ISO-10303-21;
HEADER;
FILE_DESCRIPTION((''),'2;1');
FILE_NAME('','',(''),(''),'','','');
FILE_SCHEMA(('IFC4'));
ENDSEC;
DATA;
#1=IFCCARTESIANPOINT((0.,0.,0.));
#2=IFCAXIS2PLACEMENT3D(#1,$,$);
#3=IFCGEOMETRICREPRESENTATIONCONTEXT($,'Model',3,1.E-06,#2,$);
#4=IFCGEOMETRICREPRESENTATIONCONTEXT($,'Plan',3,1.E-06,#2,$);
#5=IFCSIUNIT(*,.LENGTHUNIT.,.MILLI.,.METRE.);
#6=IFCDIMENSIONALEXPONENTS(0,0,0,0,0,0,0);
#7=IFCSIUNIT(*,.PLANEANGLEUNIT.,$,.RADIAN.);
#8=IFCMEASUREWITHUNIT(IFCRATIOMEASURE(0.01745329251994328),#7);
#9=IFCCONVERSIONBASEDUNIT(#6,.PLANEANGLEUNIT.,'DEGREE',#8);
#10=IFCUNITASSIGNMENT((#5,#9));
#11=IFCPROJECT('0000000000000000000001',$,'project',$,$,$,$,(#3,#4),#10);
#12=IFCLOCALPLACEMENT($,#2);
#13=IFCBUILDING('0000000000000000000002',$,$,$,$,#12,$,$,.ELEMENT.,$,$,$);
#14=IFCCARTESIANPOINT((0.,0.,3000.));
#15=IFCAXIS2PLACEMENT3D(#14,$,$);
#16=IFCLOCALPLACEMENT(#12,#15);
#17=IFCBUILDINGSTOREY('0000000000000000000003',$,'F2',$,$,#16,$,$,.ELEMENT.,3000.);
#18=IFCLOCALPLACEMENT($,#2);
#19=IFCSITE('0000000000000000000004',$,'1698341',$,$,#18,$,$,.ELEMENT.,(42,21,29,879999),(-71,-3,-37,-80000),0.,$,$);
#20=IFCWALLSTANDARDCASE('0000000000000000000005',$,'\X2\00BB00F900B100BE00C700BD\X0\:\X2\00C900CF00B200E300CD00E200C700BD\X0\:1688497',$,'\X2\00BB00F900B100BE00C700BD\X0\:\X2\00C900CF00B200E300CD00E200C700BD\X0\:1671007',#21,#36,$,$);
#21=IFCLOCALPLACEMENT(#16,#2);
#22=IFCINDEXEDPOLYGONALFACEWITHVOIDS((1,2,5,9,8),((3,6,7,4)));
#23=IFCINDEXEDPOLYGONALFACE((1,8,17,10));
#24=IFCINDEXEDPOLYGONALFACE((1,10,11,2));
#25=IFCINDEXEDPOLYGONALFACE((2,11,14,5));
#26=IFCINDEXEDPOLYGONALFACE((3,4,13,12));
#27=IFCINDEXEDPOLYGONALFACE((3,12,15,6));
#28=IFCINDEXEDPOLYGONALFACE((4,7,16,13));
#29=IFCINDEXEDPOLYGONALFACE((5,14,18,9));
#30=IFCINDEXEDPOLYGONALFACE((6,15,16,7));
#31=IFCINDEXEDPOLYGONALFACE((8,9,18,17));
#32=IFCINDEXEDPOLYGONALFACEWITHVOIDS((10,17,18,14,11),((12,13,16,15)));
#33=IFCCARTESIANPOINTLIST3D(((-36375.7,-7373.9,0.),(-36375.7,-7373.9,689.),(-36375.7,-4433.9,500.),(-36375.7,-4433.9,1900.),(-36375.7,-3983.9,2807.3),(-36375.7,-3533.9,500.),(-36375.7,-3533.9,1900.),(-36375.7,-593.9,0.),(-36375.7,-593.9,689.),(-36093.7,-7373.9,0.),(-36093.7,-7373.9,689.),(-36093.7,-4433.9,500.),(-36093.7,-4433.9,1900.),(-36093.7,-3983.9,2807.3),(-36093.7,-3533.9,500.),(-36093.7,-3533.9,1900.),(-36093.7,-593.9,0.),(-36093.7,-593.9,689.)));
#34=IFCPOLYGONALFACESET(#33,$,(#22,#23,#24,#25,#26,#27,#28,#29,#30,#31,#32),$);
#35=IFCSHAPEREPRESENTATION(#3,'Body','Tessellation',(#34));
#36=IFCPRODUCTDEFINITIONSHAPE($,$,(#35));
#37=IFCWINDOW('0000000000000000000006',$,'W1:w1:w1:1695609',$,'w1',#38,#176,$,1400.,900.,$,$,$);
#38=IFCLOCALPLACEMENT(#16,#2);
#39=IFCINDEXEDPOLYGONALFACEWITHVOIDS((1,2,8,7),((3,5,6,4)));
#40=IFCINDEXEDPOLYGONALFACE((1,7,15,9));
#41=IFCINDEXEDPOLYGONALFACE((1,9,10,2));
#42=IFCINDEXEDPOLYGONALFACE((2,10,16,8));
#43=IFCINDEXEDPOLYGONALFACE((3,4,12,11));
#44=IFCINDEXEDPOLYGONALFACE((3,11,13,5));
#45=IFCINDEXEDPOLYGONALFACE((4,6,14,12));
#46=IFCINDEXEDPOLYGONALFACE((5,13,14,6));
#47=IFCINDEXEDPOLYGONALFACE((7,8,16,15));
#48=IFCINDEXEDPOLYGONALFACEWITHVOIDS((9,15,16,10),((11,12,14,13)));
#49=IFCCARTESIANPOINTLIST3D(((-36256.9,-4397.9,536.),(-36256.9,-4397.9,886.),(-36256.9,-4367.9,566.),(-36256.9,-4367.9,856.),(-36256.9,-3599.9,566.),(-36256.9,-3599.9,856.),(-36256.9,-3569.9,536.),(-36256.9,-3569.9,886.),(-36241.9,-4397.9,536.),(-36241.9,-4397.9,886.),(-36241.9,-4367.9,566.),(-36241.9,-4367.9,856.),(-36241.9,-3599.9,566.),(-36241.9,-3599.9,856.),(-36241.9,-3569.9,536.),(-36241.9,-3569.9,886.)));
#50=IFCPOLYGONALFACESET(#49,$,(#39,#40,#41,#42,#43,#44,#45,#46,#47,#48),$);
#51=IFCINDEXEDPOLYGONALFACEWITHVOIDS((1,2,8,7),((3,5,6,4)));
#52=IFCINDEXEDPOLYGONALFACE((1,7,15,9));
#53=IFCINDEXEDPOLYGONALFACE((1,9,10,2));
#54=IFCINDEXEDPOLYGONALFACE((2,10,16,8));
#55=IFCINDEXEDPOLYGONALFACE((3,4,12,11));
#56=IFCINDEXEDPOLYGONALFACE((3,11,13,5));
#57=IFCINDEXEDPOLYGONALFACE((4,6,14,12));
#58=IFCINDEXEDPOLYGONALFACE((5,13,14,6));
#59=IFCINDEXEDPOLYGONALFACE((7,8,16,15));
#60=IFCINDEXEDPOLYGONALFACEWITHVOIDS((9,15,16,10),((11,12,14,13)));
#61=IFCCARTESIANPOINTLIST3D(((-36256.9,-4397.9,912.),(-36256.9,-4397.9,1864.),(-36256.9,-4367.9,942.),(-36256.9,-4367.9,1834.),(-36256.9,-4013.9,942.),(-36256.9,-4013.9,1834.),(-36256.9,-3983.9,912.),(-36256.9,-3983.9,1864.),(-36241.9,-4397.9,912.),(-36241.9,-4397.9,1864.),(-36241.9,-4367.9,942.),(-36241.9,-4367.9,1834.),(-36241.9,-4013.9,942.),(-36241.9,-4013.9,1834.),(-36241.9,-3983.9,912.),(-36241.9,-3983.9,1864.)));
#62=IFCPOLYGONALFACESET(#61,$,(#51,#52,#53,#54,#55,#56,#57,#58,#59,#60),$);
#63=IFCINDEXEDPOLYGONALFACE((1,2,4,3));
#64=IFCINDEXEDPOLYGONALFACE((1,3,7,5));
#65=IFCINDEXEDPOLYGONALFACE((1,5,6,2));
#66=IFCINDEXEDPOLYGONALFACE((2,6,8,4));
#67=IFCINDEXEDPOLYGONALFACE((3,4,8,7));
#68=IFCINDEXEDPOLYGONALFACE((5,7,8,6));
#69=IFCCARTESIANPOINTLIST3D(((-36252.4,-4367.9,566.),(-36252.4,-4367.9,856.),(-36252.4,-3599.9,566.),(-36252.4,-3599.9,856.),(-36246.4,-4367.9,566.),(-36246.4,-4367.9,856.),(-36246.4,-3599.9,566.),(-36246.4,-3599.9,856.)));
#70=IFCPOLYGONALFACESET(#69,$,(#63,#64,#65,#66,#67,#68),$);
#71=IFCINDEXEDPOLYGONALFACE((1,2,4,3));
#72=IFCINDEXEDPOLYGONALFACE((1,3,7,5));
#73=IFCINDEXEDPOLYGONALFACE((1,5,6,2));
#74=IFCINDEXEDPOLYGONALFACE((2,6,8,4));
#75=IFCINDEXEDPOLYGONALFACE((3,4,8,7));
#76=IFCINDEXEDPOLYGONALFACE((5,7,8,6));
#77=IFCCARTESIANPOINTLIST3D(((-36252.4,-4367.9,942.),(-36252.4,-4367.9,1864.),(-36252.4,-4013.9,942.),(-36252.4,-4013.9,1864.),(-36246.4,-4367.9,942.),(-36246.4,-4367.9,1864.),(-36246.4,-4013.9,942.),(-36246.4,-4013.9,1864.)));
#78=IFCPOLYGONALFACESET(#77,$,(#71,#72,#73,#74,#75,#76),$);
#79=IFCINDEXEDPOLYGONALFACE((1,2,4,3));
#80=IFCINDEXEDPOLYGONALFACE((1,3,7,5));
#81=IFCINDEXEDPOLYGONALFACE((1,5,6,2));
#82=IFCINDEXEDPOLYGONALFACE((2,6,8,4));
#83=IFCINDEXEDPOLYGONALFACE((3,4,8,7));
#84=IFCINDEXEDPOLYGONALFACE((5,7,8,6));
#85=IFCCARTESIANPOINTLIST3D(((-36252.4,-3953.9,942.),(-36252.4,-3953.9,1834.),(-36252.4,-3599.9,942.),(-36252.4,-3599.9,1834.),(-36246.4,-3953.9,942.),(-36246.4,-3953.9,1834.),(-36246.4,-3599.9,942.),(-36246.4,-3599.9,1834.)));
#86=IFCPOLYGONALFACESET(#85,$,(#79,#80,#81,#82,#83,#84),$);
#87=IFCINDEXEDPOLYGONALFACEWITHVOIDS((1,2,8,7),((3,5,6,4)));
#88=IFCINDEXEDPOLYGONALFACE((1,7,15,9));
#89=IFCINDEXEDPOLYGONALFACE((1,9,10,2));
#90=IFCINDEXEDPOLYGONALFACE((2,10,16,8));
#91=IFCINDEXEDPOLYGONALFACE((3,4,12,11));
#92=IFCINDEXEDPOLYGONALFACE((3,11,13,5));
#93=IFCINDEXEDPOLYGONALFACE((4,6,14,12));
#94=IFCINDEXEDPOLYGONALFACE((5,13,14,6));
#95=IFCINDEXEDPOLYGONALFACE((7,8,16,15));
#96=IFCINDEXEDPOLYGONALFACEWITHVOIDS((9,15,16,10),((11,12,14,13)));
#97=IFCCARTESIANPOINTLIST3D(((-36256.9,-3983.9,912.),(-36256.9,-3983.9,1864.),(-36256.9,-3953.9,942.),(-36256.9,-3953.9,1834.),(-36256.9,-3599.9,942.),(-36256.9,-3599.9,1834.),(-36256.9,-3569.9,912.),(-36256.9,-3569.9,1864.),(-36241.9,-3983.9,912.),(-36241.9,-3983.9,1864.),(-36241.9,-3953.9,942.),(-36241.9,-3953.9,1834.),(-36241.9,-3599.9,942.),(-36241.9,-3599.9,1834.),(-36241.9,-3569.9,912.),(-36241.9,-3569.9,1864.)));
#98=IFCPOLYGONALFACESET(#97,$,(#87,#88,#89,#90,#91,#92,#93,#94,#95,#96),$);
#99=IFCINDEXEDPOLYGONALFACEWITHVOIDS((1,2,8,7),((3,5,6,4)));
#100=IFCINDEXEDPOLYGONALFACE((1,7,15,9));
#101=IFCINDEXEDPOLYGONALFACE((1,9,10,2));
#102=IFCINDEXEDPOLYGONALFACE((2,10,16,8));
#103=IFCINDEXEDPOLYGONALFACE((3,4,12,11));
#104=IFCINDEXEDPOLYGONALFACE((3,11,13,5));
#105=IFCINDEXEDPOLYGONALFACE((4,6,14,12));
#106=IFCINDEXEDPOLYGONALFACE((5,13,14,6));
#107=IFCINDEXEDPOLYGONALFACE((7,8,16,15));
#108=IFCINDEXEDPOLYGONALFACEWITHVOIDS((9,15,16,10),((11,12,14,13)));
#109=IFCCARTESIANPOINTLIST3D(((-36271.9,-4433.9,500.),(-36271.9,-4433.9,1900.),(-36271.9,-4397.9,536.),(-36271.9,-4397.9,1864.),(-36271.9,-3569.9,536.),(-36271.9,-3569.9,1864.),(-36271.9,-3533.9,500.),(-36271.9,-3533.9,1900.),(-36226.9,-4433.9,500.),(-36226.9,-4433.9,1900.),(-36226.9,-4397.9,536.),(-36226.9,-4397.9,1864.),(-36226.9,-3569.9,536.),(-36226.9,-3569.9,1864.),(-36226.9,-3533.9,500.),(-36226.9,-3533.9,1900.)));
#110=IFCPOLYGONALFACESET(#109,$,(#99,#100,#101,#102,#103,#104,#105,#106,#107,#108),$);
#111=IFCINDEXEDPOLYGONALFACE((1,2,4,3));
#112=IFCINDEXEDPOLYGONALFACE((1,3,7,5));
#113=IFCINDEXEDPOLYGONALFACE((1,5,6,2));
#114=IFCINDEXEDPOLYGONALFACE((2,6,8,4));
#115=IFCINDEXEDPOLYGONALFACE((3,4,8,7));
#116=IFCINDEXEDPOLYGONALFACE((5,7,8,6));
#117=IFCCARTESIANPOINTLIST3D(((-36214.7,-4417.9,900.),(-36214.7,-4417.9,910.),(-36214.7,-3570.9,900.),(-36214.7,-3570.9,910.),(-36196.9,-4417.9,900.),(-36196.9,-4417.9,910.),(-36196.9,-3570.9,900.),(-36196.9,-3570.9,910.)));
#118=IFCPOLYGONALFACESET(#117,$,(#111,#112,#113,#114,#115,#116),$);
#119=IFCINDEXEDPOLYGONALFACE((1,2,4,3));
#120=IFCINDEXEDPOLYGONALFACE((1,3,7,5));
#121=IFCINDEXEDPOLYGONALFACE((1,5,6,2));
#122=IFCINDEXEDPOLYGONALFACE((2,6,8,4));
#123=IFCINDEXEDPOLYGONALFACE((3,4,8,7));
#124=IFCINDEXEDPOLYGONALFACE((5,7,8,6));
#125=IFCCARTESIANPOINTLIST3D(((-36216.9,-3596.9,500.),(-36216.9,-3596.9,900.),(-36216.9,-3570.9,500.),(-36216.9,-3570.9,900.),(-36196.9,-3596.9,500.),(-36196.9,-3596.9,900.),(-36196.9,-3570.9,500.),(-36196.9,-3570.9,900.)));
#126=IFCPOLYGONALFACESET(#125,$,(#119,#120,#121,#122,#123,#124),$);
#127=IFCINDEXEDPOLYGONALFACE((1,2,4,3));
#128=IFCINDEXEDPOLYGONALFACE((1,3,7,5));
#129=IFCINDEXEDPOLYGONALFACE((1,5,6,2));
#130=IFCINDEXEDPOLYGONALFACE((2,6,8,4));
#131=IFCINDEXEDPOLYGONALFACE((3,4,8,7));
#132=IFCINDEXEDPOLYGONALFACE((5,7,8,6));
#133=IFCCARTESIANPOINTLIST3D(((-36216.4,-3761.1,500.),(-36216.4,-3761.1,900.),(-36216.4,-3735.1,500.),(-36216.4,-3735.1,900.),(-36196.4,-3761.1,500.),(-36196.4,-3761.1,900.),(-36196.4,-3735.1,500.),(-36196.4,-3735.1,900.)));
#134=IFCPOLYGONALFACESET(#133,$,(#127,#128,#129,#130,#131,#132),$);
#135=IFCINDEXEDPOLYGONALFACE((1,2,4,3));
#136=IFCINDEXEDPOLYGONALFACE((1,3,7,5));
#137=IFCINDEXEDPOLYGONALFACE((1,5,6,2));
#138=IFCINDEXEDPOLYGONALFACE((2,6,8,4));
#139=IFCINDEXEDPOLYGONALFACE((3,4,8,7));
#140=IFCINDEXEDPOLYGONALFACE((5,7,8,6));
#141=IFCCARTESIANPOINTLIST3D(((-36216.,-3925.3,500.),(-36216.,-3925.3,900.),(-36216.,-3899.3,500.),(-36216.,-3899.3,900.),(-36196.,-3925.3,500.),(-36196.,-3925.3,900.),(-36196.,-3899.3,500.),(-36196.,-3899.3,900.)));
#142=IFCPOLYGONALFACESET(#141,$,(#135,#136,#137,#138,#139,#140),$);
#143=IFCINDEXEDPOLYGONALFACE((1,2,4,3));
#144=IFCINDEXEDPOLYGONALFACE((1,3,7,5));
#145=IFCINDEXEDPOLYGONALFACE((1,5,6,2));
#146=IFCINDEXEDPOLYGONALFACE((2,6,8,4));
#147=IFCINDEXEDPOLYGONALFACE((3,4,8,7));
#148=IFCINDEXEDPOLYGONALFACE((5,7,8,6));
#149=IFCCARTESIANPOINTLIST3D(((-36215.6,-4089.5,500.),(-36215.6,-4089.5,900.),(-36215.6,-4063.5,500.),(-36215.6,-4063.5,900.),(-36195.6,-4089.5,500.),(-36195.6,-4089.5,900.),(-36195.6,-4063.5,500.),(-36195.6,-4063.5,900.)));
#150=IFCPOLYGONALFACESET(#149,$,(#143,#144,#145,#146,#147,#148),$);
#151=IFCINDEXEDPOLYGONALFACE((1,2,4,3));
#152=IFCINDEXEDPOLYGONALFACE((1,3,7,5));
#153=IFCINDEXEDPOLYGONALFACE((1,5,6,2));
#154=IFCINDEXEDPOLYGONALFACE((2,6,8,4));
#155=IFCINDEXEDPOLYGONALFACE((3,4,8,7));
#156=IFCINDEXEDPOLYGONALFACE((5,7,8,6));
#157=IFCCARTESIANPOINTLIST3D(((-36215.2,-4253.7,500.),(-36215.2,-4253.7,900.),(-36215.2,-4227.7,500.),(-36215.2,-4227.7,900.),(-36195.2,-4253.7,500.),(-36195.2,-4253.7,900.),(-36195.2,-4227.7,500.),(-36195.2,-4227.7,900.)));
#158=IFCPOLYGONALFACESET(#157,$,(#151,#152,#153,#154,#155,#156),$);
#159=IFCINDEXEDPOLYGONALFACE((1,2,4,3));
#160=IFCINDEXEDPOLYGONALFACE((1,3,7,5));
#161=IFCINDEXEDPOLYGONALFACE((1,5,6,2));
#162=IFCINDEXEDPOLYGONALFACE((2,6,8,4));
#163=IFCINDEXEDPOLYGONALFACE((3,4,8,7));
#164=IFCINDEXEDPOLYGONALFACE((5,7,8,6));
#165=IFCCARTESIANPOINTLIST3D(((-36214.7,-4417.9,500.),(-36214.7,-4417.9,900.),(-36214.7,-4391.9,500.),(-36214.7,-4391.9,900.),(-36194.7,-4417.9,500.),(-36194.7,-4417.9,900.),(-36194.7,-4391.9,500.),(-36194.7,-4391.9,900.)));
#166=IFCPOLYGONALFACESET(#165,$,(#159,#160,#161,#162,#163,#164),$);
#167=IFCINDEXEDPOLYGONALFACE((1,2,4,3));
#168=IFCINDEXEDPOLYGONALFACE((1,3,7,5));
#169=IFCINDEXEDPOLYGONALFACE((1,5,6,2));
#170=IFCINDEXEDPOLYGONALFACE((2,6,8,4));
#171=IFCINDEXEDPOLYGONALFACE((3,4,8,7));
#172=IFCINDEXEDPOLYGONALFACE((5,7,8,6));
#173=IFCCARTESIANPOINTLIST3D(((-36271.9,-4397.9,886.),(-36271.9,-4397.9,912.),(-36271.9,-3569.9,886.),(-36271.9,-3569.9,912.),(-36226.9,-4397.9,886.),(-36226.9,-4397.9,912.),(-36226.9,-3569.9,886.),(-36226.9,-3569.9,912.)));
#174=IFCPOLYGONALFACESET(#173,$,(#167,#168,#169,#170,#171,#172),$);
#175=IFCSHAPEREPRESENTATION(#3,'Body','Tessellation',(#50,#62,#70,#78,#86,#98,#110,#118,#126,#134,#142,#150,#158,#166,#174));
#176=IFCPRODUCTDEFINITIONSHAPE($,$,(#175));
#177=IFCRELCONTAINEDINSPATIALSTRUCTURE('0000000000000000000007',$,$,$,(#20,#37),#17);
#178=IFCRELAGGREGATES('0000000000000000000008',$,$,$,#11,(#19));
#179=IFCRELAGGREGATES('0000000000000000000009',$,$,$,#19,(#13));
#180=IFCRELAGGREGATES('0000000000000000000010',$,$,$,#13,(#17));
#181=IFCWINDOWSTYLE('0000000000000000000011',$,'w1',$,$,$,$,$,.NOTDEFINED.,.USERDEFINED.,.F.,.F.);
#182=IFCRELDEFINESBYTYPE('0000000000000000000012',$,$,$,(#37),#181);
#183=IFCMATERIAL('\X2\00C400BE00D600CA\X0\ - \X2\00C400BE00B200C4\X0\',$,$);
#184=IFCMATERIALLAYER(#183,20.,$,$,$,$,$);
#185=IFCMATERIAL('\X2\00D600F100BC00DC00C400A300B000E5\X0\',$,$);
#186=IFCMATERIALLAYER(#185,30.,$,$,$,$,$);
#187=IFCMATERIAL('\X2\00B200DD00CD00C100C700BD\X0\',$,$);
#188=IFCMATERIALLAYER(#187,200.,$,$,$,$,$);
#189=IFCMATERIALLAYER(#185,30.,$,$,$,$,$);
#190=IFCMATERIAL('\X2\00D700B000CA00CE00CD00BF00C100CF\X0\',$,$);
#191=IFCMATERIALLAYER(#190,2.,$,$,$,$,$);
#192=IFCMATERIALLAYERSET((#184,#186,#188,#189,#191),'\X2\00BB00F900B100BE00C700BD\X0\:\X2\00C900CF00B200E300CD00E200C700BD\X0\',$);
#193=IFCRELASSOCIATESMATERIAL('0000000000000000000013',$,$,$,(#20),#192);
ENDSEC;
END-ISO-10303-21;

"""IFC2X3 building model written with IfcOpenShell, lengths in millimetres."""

from ifc_helpers import new_model, entity, si_unit, converted_unit, frame, frame_2d, origin, origin_2d_with_axis, place, context, project, spatial, polyline, rectangle, outline, extrude, clip, bounded_halfspace, source, transform, mapped, material, layer, layer_set, layer_usage, type_object, type_shapes, element, fill, save


model = new_model("IFC2X3")

# Units and contexts
model_context = context("Model", 3, precision=1e-06, world=origin())
plan_context = context("Plan", 3, precision=1e-06, world=origin())
ifc_project = project(units=[si_unit("LENGTHUNIT", "METRE", prefix="MILLI"), converted_unit("PLANEANGLEUNIT", "DEGREE", entity("IfcRatioMeasure", 0.01745329251994328), si_unit("PLANEANGLEUNIT", "RADIAN"), dimensions=[0, 0, 0, 0, 0, 0, 0])], contexts=[model_context, plan_context])

# Site, building, storey
site_placement = place(None, origin())
site = spatial("IfcSite", under=ifc_project, at=site_placement, Name="1698341", CompositionType="ELEMENT", RefLatitude=(42, 21, 29, 879999), RefLongitude=(-71, -3, -37, -80000), RefElevation=0.0)
building_placement = place(None, origin())
building = spatial("IfcBuilding", under=site, at=building_placement, CompositionType="ELEMENT")
storey_placement = place(building_placement, frame((0.0, 0.0, 3000.0)))
storey = spatial("IfcBuildingStorey", under=building, at=storey_placement, Name="F2", CompositionType="ELEMENT", Elevation=3000.0)

# Shared definitions
ifc_material_1 = material(Name="Öñ¼ÜÄ£°å")

# Wall, opening, window
ifc_material_2 = material(Name="Ä¾ÖÊ - Ä¾²Ä")
ifc_layer_1 = layer(ifc_material_2, 20.0)
ifc_layer_2 = layer(ifc_material_1, 30.0)
ifc_material_3 = material(Name="²ÝÍÁÇ½")
ifc_layer_3 = layer(ifc_material_3, 200.0)
ifc_layer_4 = layer(ifc_material_1, 30.0)
ifc_material_4 = material(Name="×°ÊÎÍ¿ÁÏ")
ifc_layer_5 = layer(ifc_material_4, 2.0)
ifc_layer_set_1 = layer_set([ifc_layer_1, ifc_layer_2, ifc_layer_3, ifc_layer_4, ifc_layer_5], Name="»ù±¾Ç½:ÉÏ²ãÍâÇ½")
ifc_layer_usage_1 = layer_usage(ifc_layer_set_1, "AXIS2", "NEGATIVE", 141.0)
wall_1_placement = place(storey_placement, frame((-36234.7, -7373.9, 0.0), z_axis=(0.0, 0.0, 1.0), x_axis=(0.0, 1.0, 0.0)))
wall_1 = element("IfcWallStandardCase", 1, at=wall_1_placement, inside=storey, material=ifc_layer_usage_1, Name="»ù±¾Ç½:ÉÏ²ãÍâÇ½:1688497", ObjectType="»ù±¾Ç½:ÉÏ²ãÍâÇ½:1671007", context=model_context, shape_type="Clipping", body=[
    clip(clip(extrude(rectangle(XDim=6780.0, YDim=282.0, at=frame_2d((3390.0, 0.0), x_axis=(-1.0, 0.0))), origin(), (0.0, 0.0, 1.0), 3200.0), bounded_halfspace(frame((3390.0, -141.0, 2807.3), z_axis=(0.529919, 0.0, 0.848048), x_axis=(0.0, 1.0, 0.0)), False, frame((3390.0, -141.0, 2807.3)), polyline([(0.0, 0.0), (3390.0, 0.0), (3390.0, 282.0), (0.0, 282.0), (0.0, 0.0)]))), bounded_halfspace(frame((0.0, -141.0, 689.0), z_axis=(-0.529919, 0.0, 0.848048), x_axis=(0.0, -1.0, 0.0)), False, frame((0.0, -141.0, 689.0)), polyline([(0.0, 0.0), (3390.0, 0.0), (3390.0, 282.0), (0.0, 282.0), (0.0, 0.0)]))),
])
opening_1_placement = place(wall_1_placement, frame((2940.0, -141.0, 500.0)))
opening_1 = element("IfcOpeningElement", 2, at=opening_1_placement, cuts=wall_1, ObjectType="Opening", context=model_context, shape_type="SweptSolid", body=[
    extrude(rectangle(XDim=1400.0, YDim=900.0, at=frame_2d((700.0, 450.0), x_axis=(-1.0, 0.0))), frame((0.0, 0.0, 0.0), z_axis=(0.0, 1.0, 0.0), x_axis=(0.0, 0.0, 1.0)), (0.0, 0.0, 1.0), 282.0),
])
window_style_1 = type_object("IfcWindowStyle", Name="w1", ConstructionType="NOTDEFINED", OperationType="USERDEFINED", ParameterTakesPrecedence=False, Sizeable=False)
shared_shape_1 = source(origin(), model_context, "Body", "SweptSolid", [
    extrude(outline(polyline([(-175.0, -414.0), (175.0, -414.0), (175.0, 414.0), (-175.0, 414.0), (-175.0, -414.0)]), holes=[polyline([(145.0, -384.0), (-145.0, -384.0), (-145.0, 384.0), (145.0, 384.0), (145.0, -384.0)])]), frame((450.0, 148.1, 211.0), z_axis=(0.0, 1.0, 0.0), x_axis=(0.0, 0.0, 1.0)), (0.0, 0.0, 1.0), 15.0),
    extrude(outline(polyline([(-476.0, -207.0), (476.0, -207.0), (476.0, 207.0), (-476.0, 207.0), (-476.0, -207.0)]), holes=[polyline([(446.0, -177.0), (-446.0, -177.0), (-446.0, 177.0), (446.0, 177.0), (446.0, -177.0)])]), frame((243.0, 148.1, 888.0), z_axis=(0.0, 1.0, 0.0), x_axis=(0.0, 0.0, 1.0)), (0.0, 0.0, 1.0), 15.0),
    extrude(rectangle(XDim=6.0, YDim=768.0, at=origin_2d_with_axis()), frame((450.0, 155.6, 66.0), z_axis=(0.0, 0.0, 1.0), x_axis=(0.0, 1.0, 0.0)), (0.0, 0.0, 1.0), 290.0),
    extrude(rectangle(XDim=6.0, YDim=354.0, at=origin_2d_with_axis()), frame((243.0, 155.6, 442.0), z_axis=(0.0, 0.0, 1.0), x_axis=(0.0, 1.0, 0.0)), (0.0, 0.0, 1.0), 922.0),
    extrude(rectangle(XDim=6.0, YDim=354.0, at=origin_2d_with_axis()), frame((657.0, 155.6, 442.0), z_axis=(0.0, 0.0, 1.0), x_axis=(0.0, 1.0, 0.0)), (0.0, 0.0, 1.0), 892.0),
    extrude(outline(polyline([(-476.0, -207.0), (476.0, -207.0), (476.0, 207.0), (-476.0, 207.0), (-476.0, -207.0)]), holes=[polyline([(446.0, -177.0), (-446.0, -177.0), (-446.0, 177.0), (446.0, 177.0), (446.0, -177.0)])]), frame((657.0, 148.1, 888.0), z_axis=(0.0, 1.0, 0.0), x_axis=(0.0, 0.0, 1.0)), (0.0, 0.0, 1.0), 15.0),
    extrude(outline(polyline([(-700.0, -450.0), (700.0, -450.0), (700.0, 450.0), (-700.0, 450.0), (-700.0, -450.0)]), holes=[polyline([(664.0, -414.0), (-664.0, -414.0), (-664.0, 414.0), (664.0, 414.0), (664.0, -414.0)])]), frame((450.0, 133.1, 700.0), z_axis=(0.0, 1.0, 0.0), x_axis=(0.0, 0.0, 1.0)), (0.0, 0.0, 1.0), 45.0),
    extrude(rectangle(XDim=847.1, YDim=17.9, at=origin_2d_with_axis()), frame((439.5, 112.1, 400.0), z_axis=(0.0, 0.0, 1.0), x_axis=(-1.0, 0.0, 0.0)), (0.0, 0.0, 1.0), 10.0),
    extrude(rectangle(XDim=26.0, YDim=20.0, at=origin_2d_with_axis()), frame((850.0, 113.1, 0.0), z_axis=(0.0, 0.0, 1.0), x_axis=(-1.0, 0.0, 0.0)), (0.0, 0.0, 1.0), 400.0),
    extrude(rectangle(XDim=26.0, YDim=20.0, at=origin_2d_with_axis()), frame((685.8, 112.7, 0.0), z_axis=(0.0, 0.0, 1.0), x_axis=(-1.0, 0.0, 0.0)), (0.0, 0.0, 1.0), 400.0),
    extrude(rectangle(XDim=26.0, YDim=20.0, at=origin_2d_with_axis()), frame((521.6, 112.3, 0.0), z_axis=(0.0, 0.0, 1.0), x_axis=(-1.0, 0.0, 0.0)), (0.0, 0.0, 1.0), 400.0),
    extrude(rectangle(XDim=26.0, YDim=20.0, at=origin_2d_with_axis()), frame((357.4, 111.9, 0.0), z_axis=(0.0, 0.0, 1.0), x_axis=(-1.0, 0.0, 0.0)), (0.0, 0.0, 1.0), 400.0),
    extrude(rectangle(XDim=26.0, YDim=20.0, at=origin_2d_with_axis()), frame((193.2, 111.4, 0.0), z_axis=(0.0, 0.0, 1.0), x_axis=(-1.0, 0.0, 0.0)), (0.0, 0.0, 1.0), 400.0),
    extrude(rectangle(XDim=26.0, YDim=20.0, at=origin_2d_with_axis()), frame((28.9, 111.0, 0.0), z_axis=(0.0, 0.0, 1.0), x_axis=(-1.0, 0.0, 0.0)), (0.0, 0.0, 1.0), 400.0),
    extrude(rectangle(XDim=45.0, YDim=828.0, at=origin_2d_with_axis()), frame((450.0, 155.6, 386.0), z_axis=(0.0, 0.0, 1.0), x_axis=(0.0, 1.0, 0.0)), (0.0, 0.0, 1.0), 26.0),
])
type_shapes(window_style_1, [shared_shape_1])
window_1_placement = place(opening_1_placement, origin())
window_1 = element("IfcWindow", 3, at=window_1_placement, inside=storey, type_object=window_style_1, Name="W1:w1:w1:1695609", ObjectType="w1", OverallHeight=1400.0, OverallWidth=900.0, context=model_context, shape_type="MappedRepresentation", body=[
    mapped(shared_shape_1, transform((0.0, 0.0, 0.0), scale=1.0)),
])
fill(opening_1, window_1)

save(model, "model.ifc")
